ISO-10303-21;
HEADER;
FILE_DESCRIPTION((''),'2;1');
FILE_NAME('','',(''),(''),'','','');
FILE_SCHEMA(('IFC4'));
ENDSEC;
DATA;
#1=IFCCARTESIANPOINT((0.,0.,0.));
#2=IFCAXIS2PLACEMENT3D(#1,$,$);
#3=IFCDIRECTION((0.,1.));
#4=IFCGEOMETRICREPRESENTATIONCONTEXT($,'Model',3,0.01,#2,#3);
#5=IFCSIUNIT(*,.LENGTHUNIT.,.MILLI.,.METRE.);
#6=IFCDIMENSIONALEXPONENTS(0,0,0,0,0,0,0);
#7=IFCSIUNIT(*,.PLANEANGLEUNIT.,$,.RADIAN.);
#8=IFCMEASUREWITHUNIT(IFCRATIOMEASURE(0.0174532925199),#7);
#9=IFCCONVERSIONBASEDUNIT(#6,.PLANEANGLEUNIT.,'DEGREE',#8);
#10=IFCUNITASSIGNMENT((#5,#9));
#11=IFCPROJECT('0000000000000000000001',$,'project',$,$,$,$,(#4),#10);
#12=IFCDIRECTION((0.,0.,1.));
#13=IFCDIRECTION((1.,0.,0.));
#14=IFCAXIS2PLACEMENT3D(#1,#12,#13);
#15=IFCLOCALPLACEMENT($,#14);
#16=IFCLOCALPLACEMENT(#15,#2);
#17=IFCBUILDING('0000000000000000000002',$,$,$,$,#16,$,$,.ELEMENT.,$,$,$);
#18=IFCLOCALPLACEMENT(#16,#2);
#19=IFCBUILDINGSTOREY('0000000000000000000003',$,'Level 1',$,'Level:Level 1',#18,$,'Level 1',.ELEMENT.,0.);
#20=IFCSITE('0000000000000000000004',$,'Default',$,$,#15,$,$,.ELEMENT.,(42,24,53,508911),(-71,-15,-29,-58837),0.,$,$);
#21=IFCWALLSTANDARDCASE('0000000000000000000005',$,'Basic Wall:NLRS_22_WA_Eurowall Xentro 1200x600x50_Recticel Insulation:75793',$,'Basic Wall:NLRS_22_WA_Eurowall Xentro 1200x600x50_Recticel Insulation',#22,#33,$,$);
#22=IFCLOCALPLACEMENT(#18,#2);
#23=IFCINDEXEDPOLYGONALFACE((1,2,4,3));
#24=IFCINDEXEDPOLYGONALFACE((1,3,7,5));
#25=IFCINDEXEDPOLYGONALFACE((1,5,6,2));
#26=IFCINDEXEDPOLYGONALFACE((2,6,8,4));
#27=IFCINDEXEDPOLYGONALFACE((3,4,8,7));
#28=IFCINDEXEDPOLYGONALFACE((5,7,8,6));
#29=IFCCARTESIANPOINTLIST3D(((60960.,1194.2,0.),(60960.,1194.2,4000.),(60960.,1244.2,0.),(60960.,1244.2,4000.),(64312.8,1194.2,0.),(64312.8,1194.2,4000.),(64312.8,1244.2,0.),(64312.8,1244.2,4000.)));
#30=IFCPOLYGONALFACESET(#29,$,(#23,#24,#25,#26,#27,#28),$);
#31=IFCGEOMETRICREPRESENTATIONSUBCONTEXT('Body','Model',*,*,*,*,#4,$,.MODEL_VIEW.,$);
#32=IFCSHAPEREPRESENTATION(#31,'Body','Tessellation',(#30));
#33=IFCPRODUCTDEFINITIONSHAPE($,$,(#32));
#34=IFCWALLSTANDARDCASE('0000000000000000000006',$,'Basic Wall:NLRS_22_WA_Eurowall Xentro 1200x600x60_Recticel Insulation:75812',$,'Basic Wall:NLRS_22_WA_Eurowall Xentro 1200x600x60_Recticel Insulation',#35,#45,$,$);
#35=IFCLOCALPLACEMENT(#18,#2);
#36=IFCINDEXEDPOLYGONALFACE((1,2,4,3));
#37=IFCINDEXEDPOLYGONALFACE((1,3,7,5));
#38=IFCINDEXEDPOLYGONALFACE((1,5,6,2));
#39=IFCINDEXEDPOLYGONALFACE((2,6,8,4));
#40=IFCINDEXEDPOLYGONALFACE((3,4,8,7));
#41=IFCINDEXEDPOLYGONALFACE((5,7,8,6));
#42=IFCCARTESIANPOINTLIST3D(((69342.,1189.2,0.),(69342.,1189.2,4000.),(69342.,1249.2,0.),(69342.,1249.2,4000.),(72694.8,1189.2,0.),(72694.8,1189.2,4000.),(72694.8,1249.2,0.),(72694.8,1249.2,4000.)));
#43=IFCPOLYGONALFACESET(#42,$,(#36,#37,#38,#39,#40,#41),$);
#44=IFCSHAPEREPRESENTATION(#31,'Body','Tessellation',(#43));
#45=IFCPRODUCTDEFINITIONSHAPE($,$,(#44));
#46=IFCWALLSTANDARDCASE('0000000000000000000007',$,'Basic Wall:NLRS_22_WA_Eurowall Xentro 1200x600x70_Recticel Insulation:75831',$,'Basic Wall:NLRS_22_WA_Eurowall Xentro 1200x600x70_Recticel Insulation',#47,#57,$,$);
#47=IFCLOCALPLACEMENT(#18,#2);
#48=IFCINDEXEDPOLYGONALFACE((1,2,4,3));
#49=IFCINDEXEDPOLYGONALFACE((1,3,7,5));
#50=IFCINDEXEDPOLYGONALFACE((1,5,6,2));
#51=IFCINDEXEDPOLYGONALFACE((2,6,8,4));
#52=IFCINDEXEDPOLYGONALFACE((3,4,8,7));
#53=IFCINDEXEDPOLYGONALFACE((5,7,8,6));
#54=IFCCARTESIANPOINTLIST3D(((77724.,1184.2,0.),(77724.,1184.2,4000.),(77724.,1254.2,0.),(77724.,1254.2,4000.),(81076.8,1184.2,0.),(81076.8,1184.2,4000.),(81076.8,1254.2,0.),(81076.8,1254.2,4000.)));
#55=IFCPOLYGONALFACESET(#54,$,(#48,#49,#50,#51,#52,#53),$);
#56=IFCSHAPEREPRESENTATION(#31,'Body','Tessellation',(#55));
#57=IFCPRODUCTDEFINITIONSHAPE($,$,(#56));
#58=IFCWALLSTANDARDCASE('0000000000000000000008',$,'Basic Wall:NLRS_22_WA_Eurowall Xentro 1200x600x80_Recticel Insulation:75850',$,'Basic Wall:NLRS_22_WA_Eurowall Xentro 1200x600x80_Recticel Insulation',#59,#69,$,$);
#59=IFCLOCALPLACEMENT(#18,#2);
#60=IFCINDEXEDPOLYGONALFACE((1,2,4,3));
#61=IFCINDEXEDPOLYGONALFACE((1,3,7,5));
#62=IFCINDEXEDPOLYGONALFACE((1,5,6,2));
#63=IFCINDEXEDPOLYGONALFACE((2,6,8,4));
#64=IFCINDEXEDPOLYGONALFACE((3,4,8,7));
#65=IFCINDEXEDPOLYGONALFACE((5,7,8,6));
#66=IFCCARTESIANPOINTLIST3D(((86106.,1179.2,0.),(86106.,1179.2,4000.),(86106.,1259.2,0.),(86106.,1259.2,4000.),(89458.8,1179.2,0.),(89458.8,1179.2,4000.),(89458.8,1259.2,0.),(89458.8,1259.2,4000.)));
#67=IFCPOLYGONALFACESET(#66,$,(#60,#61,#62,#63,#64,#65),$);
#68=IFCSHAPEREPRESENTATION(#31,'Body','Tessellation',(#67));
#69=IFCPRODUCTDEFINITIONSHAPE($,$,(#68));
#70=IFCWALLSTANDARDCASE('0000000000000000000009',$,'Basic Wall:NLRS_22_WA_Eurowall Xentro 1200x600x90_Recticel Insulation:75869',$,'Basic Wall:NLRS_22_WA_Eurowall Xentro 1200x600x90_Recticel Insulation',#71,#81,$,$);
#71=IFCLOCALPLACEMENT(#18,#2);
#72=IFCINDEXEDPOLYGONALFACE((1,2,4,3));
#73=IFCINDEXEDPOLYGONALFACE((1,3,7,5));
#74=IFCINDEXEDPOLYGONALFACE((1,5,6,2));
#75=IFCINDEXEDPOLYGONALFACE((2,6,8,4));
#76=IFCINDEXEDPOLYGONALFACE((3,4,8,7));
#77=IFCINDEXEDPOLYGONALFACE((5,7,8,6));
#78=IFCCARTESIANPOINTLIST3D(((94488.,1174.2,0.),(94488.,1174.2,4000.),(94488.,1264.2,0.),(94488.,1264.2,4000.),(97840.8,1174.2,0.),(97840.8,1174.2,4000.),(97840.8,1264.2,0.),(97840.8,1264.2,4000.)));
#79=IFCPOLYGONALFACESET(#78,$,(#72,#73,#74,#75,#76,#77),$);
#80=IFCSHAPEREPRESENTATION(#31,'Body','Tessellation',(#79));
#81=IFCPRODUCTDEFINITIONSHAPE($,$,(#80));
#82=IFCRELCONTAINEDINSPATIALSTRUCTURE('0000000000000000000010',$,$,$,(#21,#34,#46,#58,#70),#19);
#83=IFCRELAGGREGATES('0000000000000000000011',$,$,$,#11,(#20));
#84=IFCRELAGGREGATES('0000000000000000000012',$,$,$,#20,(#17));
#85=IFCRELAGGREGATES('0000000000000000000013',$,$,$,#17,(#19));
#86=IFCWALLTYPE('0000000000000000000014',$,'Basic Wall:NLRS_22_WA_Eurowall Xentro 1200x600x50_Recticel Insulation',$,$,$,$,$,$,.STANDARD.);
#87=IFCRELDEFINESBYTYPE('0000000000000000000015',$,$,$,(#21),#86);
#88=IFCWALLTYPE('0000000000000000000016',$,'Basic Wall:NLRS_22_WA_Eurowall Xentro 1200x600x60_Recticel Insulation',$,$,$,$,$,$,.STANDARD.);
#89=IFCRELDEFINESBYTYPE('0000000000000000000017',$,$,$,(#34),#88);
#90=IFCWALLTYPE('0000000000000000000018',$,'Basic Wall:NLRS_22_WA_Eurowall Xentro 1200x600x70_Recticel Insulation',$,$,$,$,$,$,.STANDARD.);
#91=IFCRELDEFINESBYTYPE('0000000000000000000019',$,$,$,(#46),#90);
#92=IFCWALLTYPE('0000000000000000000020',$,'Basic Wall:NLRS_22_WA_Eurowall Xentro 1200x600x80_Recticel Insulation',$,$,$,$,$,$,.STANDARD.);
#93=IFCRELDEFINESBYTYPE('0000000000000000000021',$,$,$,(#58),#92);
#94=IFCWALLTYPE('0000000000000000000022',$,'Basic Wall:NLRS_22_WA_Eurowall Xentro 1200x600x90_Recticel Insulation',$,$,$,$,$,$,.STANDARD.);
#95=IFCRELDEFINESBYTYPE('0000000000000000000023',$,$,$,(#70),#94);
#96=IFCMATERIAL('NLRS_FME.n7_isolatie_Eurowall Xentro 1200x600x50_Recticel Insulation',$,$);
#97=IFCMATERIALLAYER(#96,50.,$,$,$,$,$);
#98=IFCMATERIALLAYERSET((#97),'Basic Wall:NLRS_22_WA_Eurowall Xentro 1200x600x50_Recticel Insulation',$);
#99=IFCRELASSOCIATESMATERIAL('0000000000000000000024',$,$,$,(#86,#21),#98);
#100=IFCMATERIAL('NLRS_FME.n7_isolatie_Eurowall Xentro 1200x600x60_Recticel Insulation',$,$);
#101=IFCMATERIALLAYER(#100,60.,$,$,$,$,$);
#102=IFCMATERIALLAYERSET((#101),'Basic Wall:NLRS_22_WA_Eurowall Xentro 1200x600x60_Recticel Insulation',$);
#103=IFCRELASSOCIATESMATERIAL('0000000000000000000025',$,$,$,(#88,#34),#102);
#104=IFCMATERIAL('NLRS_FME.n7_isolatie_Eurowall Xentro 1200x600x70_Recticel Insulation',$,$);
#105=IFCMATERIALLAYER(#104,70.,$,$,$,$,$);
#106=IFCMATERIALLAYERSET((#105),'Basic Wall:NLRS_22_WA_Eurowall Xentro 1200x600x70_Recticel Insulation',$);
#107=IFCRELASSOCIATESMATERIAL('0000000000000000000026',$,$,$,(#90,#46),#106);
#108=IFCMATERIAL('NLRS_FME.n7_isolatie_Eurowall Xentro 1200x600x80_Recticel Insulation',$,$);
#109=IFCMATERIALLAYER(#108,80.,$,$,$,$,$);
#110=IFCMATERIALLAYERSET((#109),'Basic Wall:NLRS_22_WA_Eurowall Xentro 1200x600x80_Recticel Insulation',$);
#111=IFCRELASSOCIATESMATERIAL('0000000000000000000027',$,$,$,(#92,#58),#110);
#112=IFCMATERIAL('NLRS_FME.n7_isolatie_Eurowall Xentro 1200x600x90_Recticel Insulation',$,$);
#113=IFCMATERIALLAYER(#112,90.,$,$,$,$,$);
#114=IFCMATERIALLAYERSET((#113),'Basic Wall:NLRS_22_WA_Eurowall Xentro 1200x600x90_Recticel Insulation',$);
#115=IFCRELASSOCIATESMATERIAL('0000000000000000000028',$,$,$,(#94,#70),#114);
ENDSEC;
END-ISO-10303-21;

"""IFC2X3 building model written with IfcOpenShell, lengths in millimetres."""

from ifc_helpers import new_model, entity, si_unit, converted_unit, direction, frame, origin, origin_with_axes, origin_2d_with_axis, place, context, subcontext, project, spatial, rectangle, extrude, material, layer, layer_set, layer_usage, type_object, element, save


model = new_model("IFC2X3")

# Units and contexts
model_context = context("Model", 3, precision=0.01, world=origin(), true_north=direction((0.0, 1.0)))
body_context = subcontext(model_context, "Body", "Model", "MODEL_VIEW")
ifc_project = project(units=[si_unit("LENGTHUNIT", "METRE", prefix="MILLI"), converted_unit("PLANEANGLEUNIT", "DEGREE", entity("IfcRatioMeasure", 0.0174532925199), si_unit("PLANEANGLEUNIT", "RADIAN"), dimensions=[0, 0, 0, 0, 0, 0, 0])], contexts=[model_context])

# Site, building, storey
site_placement = place(None, origin_with_axes())
site = spatial("IfcSite", under=ifc_project, at=site_placement, Name="Default", CompositionType="ELEMENT", RefLatitude=(42, 24, 53, 508911), RefLongitude=(-71, -15, -29, -58837), RefElevation=0.0)
building_placement = place(site_placement, origin())
building = spatial("IfcBuilding", under=site, at=building_placement, CompositionType="ELEMENT")
storey_placement = place(building_placement, origin())
storey = spatial("IfcBuildingStorey", under=building, at=storey_placement, Name="Level 1", ObjectType="Level:Level 1", LongName="Level 1", CompositionType="ELEMENT", Elevation=0.0)

# Walls
ifc_material_1 = material(Name="NLRS_FME.n7_isolatie_Eurowall Xentro 1200x600x50_Recticel Insulation")
ifc_layer_1 = layer(ifc_material_1, 50.0)
ifc_layer_set_1 = layer_set([ifc_layer_1], Name="Basic Wall:NLRS_22_WA_Eurowall Xentro 1200x600x50_Recticel Insulation")
ifc_layer_usage_1 = layer_usage(ifc_layer_set_1, "AXIS2", "NEGATIVE", 25.0)
wall_type_1 = type_object("IfcWallType", Name="Basic Wall:NLRS_22_WA_Eurowall Xentro 1200x600x50_Recticel Insulation", PredefinedType="STANDARD", material=ifc_layer_set_1)
wall_1_placement = place(storey_placement, frame((60960.0, 1219.2, 0.0)))
element("IfcWallStandardCase", 1, at=wall_1_placement, inside=storey, type_object=wall_type_1, material=ifc_layer_usage_1, Name="Basic Wall:NLRS_22_WA_Eurowall Xentro 1200x600x50_Recticel Insulation:75793", ObjectType="Basic Wall:NLRS_22_WA_Eurowall Xentro 1200x600x50_Recticel Insulation", context=body_context, shape_type="SweptSolid", body=[
    extrude(rectangle(XDim=3352.8, YDim=50.0, at=origin_2d_with_axis()), frame((1676.4, 0.0, 0.0), x_axis=(-1.0, 0.0, 0.0)), (0.0, 0.0, 1.0), 4000.0),
])
ifc_material_2 = material(Name="NLRS_FME.n7_isolatie_Eurowall Xentro 1200x600x60_Recticel Insulation")
ifc_layer_2 = layer(ifc_material_2, 60.0)
ifc_layer_set_2 = layer_set([ifc_layer_2], Name="Basic Wall:NLRS_22_WA_Eurowall Xentro 1200x600x60_Recticel Insulation")
ifc_layer_usage_2 = layer_usage(ifc_layer_set_2, "AXIS2", "NEGATIVE", 30.0)
wall_type_2 = type_object("IfcWallType", Name="Basic Wall:NLRS_22_WA_Eurowall Xentro 1200x600x60_Recticel Insulation", PredefinedType="STANDARD", material=ifc_layer_set_2)
wall_2_placement = place(storey_placement, frame((69342.0, 1219.2, 0.0)))
element("IfcWallStandardCase", 2, at=wall_2_placement, inside=storey, type_object=wall_type_2, material=ifc_layer_usage_2, Name="Basic Wall:NLRS_22_WA_Eurowall Xentro 1200x600x60_Recticel Insulation:75812", ObjectType="Basic Wall:NLRS_22_WA_Eurowall Xentro 1200x600x60_Recticel Insulation", context=body_context, shape_type="SweptSolid", body=[
    extrude(rectangle(XDim=3352.8, YDim=60.0, at=origin_2d_with_axis()), frame((1676.4, 0.0, 0.0), x_axis=(-1.0, 0.0, 0.0)), (0.0, 0.0, 1.0), 4000.0),
])
ifc_material_3 = material(Name="NLRS_FME.n7_isolatie_Eurowall Xentro 1200x600x70_Recticel Insulation")
ifc_layer_3 = layer(ifc_material_3, 70.0)
ifc_layer_set_3 = layer_set([ifc_layer_3], Name="Basic Wall:NLRS_22_WA_Eurowall Xentro 1200x600x70_Recticel Insulation")
ifc_layer_usage_3 = layer_usage(ifc_layer_set_3, "AXIS2", "NEGATIVE", 35.0)
wall_type_3 = type_object("IfcWallType", Name="Basic Wall:NLRS_22_WA_Eurowall Xentro 1200x600x70_Recticel Insulation", PredefinedType="STANDARD", material=ifc_layer_set_3)
wall_3_placement = place(storey_placement, frame((77724.0, 1219.2, 0.0)))
element("IfcWallStandardCase", 3, at=wall_3_placement, inside=storey, type_object=wall_type_3, material=ifc_layer_usage_3, Name="Basic Wall:NLRS_22_WA_Eurowall Xentro 1200x600x70_Recticel Insulation:75831", ObjectType="Basic Wall:NLRS_22_WA_Eurowall Xentro 1200x600x70_Recticel Insulation", context=body_context, shape_type="SweptSolid", body=[
    extrude(rectangle(XDim=3352.8, YDim=70.0, at=origin_2d_with_axis()), frame((1676.4, 0.0, 0.0), x_axis=(-1.0, 0.0, 0.0)), (0.0, 0.0, 1.0), 4000.0),
])
ifc_material_4 = material(Name="NLRS_FME.n7_isolatie_Eurowall Xentro 1200x600x80_Recticel Insulation")
ifc_layer_4 = layer(ifc_material_4, 80.0)
ifc_layer_set_4 = layer_set([ifc_layer_4], Name="Basic Wall:NLRS_22_WA_Eurowall Xentro 1200x600x80_Recticel Insulation")
ifc_layer_usage_4 = layer_usage(ifc_layer_set_4, "AXIS2", "NEGATIVE", 40.0)
wall_type_4 = type_object("IfcWallType", Name="Basic Wall:NLRS_22_WA_Eurowall Xentro 1200x600x80_Recticel Insulation", PredefinedType="STANDARD", material=ifc_layer_set_4)
wall_4_placement = place(storey_placement, frame((86106.0, 1219.2, 0.0)))
element("IfcWallStandardCase", 4, at=wall_4_placement, inside=storey, type_object=wall_type_4, material=ifc_layer_usage_4, Name="Basic Wall:NLRS_22_WA_Eurowall Xentro 1200x600x80_Recticel Insulation:75850", ObjectType="Basic Wall:NLRS_22_WA_Eurowall Xentro 1200x600x80_Recticel Insulation", context=body_context, shape_type="SweptSolid", body=[
    extrude(rectangle(XDim=3352.8, YDim=80.0, at=origin_2d_with_axis()), frame((1676.4, 0.0, 0.0), x_axis=(-1.0, 0.0, 0.0)), (0.0, 0.0, 1.0), 4000.0),
])
ifc_material_5 = material(Name="NLRS_FME.n7_isolatie_Eurowall Xentro 1200x600x90_Recticel Insulation")
ifc_layer_5 = layer(ifc_material_5, 90.0)
ifc_layer_set_5 = layer_set([ifc_layer_5], Name="Basic Wall:NLRS_22_WA_Eurowall Xentro 1200x600x90_Recticel Insulation")
ifc_layer_usage_5 = layer_usage(ifc_layer_set_5, "AXIS2", "NEGATIVE", 45.0)
wall_type_5 = type_object("IfcWallType", Name="Basic Wall:NLRS_22_WA_Eurowall Xentro 1200x600x90_Recticel Insulation", PredefinedType="STANDARD", material=ifc_layer_set_5)
wall_5_placement = place(storey_placement, frame((94488.0, 1219.2, 0.0)))
element("IfcWallStandardCase", 5, at=wall_5_placement, inside=storey, type_object=wall_type_5, material=ifc_layer_usage_5, Name="Basic Wall:NLRS_22_WA_Eurowall Xentro 1200x600x90_Recticel Insulation:75869", ObjectType="Basic Wall:NLRS_22_WA_Eurowall Xentro 1200x600x90_Recticel Insulation", context=body_context, shape_type="SweptSolid", body=[
    extrude(rectangle(XDim=3352.8, YDim=90.0, at=origin_2d_with_axis()), frame((1676.4, 0.0, 0.0), x_axis=(-1.0, 0.0, 0.0)), (0.0, 0.0, 1.0), 4000.0),
])

save(model, "model.ifc")
